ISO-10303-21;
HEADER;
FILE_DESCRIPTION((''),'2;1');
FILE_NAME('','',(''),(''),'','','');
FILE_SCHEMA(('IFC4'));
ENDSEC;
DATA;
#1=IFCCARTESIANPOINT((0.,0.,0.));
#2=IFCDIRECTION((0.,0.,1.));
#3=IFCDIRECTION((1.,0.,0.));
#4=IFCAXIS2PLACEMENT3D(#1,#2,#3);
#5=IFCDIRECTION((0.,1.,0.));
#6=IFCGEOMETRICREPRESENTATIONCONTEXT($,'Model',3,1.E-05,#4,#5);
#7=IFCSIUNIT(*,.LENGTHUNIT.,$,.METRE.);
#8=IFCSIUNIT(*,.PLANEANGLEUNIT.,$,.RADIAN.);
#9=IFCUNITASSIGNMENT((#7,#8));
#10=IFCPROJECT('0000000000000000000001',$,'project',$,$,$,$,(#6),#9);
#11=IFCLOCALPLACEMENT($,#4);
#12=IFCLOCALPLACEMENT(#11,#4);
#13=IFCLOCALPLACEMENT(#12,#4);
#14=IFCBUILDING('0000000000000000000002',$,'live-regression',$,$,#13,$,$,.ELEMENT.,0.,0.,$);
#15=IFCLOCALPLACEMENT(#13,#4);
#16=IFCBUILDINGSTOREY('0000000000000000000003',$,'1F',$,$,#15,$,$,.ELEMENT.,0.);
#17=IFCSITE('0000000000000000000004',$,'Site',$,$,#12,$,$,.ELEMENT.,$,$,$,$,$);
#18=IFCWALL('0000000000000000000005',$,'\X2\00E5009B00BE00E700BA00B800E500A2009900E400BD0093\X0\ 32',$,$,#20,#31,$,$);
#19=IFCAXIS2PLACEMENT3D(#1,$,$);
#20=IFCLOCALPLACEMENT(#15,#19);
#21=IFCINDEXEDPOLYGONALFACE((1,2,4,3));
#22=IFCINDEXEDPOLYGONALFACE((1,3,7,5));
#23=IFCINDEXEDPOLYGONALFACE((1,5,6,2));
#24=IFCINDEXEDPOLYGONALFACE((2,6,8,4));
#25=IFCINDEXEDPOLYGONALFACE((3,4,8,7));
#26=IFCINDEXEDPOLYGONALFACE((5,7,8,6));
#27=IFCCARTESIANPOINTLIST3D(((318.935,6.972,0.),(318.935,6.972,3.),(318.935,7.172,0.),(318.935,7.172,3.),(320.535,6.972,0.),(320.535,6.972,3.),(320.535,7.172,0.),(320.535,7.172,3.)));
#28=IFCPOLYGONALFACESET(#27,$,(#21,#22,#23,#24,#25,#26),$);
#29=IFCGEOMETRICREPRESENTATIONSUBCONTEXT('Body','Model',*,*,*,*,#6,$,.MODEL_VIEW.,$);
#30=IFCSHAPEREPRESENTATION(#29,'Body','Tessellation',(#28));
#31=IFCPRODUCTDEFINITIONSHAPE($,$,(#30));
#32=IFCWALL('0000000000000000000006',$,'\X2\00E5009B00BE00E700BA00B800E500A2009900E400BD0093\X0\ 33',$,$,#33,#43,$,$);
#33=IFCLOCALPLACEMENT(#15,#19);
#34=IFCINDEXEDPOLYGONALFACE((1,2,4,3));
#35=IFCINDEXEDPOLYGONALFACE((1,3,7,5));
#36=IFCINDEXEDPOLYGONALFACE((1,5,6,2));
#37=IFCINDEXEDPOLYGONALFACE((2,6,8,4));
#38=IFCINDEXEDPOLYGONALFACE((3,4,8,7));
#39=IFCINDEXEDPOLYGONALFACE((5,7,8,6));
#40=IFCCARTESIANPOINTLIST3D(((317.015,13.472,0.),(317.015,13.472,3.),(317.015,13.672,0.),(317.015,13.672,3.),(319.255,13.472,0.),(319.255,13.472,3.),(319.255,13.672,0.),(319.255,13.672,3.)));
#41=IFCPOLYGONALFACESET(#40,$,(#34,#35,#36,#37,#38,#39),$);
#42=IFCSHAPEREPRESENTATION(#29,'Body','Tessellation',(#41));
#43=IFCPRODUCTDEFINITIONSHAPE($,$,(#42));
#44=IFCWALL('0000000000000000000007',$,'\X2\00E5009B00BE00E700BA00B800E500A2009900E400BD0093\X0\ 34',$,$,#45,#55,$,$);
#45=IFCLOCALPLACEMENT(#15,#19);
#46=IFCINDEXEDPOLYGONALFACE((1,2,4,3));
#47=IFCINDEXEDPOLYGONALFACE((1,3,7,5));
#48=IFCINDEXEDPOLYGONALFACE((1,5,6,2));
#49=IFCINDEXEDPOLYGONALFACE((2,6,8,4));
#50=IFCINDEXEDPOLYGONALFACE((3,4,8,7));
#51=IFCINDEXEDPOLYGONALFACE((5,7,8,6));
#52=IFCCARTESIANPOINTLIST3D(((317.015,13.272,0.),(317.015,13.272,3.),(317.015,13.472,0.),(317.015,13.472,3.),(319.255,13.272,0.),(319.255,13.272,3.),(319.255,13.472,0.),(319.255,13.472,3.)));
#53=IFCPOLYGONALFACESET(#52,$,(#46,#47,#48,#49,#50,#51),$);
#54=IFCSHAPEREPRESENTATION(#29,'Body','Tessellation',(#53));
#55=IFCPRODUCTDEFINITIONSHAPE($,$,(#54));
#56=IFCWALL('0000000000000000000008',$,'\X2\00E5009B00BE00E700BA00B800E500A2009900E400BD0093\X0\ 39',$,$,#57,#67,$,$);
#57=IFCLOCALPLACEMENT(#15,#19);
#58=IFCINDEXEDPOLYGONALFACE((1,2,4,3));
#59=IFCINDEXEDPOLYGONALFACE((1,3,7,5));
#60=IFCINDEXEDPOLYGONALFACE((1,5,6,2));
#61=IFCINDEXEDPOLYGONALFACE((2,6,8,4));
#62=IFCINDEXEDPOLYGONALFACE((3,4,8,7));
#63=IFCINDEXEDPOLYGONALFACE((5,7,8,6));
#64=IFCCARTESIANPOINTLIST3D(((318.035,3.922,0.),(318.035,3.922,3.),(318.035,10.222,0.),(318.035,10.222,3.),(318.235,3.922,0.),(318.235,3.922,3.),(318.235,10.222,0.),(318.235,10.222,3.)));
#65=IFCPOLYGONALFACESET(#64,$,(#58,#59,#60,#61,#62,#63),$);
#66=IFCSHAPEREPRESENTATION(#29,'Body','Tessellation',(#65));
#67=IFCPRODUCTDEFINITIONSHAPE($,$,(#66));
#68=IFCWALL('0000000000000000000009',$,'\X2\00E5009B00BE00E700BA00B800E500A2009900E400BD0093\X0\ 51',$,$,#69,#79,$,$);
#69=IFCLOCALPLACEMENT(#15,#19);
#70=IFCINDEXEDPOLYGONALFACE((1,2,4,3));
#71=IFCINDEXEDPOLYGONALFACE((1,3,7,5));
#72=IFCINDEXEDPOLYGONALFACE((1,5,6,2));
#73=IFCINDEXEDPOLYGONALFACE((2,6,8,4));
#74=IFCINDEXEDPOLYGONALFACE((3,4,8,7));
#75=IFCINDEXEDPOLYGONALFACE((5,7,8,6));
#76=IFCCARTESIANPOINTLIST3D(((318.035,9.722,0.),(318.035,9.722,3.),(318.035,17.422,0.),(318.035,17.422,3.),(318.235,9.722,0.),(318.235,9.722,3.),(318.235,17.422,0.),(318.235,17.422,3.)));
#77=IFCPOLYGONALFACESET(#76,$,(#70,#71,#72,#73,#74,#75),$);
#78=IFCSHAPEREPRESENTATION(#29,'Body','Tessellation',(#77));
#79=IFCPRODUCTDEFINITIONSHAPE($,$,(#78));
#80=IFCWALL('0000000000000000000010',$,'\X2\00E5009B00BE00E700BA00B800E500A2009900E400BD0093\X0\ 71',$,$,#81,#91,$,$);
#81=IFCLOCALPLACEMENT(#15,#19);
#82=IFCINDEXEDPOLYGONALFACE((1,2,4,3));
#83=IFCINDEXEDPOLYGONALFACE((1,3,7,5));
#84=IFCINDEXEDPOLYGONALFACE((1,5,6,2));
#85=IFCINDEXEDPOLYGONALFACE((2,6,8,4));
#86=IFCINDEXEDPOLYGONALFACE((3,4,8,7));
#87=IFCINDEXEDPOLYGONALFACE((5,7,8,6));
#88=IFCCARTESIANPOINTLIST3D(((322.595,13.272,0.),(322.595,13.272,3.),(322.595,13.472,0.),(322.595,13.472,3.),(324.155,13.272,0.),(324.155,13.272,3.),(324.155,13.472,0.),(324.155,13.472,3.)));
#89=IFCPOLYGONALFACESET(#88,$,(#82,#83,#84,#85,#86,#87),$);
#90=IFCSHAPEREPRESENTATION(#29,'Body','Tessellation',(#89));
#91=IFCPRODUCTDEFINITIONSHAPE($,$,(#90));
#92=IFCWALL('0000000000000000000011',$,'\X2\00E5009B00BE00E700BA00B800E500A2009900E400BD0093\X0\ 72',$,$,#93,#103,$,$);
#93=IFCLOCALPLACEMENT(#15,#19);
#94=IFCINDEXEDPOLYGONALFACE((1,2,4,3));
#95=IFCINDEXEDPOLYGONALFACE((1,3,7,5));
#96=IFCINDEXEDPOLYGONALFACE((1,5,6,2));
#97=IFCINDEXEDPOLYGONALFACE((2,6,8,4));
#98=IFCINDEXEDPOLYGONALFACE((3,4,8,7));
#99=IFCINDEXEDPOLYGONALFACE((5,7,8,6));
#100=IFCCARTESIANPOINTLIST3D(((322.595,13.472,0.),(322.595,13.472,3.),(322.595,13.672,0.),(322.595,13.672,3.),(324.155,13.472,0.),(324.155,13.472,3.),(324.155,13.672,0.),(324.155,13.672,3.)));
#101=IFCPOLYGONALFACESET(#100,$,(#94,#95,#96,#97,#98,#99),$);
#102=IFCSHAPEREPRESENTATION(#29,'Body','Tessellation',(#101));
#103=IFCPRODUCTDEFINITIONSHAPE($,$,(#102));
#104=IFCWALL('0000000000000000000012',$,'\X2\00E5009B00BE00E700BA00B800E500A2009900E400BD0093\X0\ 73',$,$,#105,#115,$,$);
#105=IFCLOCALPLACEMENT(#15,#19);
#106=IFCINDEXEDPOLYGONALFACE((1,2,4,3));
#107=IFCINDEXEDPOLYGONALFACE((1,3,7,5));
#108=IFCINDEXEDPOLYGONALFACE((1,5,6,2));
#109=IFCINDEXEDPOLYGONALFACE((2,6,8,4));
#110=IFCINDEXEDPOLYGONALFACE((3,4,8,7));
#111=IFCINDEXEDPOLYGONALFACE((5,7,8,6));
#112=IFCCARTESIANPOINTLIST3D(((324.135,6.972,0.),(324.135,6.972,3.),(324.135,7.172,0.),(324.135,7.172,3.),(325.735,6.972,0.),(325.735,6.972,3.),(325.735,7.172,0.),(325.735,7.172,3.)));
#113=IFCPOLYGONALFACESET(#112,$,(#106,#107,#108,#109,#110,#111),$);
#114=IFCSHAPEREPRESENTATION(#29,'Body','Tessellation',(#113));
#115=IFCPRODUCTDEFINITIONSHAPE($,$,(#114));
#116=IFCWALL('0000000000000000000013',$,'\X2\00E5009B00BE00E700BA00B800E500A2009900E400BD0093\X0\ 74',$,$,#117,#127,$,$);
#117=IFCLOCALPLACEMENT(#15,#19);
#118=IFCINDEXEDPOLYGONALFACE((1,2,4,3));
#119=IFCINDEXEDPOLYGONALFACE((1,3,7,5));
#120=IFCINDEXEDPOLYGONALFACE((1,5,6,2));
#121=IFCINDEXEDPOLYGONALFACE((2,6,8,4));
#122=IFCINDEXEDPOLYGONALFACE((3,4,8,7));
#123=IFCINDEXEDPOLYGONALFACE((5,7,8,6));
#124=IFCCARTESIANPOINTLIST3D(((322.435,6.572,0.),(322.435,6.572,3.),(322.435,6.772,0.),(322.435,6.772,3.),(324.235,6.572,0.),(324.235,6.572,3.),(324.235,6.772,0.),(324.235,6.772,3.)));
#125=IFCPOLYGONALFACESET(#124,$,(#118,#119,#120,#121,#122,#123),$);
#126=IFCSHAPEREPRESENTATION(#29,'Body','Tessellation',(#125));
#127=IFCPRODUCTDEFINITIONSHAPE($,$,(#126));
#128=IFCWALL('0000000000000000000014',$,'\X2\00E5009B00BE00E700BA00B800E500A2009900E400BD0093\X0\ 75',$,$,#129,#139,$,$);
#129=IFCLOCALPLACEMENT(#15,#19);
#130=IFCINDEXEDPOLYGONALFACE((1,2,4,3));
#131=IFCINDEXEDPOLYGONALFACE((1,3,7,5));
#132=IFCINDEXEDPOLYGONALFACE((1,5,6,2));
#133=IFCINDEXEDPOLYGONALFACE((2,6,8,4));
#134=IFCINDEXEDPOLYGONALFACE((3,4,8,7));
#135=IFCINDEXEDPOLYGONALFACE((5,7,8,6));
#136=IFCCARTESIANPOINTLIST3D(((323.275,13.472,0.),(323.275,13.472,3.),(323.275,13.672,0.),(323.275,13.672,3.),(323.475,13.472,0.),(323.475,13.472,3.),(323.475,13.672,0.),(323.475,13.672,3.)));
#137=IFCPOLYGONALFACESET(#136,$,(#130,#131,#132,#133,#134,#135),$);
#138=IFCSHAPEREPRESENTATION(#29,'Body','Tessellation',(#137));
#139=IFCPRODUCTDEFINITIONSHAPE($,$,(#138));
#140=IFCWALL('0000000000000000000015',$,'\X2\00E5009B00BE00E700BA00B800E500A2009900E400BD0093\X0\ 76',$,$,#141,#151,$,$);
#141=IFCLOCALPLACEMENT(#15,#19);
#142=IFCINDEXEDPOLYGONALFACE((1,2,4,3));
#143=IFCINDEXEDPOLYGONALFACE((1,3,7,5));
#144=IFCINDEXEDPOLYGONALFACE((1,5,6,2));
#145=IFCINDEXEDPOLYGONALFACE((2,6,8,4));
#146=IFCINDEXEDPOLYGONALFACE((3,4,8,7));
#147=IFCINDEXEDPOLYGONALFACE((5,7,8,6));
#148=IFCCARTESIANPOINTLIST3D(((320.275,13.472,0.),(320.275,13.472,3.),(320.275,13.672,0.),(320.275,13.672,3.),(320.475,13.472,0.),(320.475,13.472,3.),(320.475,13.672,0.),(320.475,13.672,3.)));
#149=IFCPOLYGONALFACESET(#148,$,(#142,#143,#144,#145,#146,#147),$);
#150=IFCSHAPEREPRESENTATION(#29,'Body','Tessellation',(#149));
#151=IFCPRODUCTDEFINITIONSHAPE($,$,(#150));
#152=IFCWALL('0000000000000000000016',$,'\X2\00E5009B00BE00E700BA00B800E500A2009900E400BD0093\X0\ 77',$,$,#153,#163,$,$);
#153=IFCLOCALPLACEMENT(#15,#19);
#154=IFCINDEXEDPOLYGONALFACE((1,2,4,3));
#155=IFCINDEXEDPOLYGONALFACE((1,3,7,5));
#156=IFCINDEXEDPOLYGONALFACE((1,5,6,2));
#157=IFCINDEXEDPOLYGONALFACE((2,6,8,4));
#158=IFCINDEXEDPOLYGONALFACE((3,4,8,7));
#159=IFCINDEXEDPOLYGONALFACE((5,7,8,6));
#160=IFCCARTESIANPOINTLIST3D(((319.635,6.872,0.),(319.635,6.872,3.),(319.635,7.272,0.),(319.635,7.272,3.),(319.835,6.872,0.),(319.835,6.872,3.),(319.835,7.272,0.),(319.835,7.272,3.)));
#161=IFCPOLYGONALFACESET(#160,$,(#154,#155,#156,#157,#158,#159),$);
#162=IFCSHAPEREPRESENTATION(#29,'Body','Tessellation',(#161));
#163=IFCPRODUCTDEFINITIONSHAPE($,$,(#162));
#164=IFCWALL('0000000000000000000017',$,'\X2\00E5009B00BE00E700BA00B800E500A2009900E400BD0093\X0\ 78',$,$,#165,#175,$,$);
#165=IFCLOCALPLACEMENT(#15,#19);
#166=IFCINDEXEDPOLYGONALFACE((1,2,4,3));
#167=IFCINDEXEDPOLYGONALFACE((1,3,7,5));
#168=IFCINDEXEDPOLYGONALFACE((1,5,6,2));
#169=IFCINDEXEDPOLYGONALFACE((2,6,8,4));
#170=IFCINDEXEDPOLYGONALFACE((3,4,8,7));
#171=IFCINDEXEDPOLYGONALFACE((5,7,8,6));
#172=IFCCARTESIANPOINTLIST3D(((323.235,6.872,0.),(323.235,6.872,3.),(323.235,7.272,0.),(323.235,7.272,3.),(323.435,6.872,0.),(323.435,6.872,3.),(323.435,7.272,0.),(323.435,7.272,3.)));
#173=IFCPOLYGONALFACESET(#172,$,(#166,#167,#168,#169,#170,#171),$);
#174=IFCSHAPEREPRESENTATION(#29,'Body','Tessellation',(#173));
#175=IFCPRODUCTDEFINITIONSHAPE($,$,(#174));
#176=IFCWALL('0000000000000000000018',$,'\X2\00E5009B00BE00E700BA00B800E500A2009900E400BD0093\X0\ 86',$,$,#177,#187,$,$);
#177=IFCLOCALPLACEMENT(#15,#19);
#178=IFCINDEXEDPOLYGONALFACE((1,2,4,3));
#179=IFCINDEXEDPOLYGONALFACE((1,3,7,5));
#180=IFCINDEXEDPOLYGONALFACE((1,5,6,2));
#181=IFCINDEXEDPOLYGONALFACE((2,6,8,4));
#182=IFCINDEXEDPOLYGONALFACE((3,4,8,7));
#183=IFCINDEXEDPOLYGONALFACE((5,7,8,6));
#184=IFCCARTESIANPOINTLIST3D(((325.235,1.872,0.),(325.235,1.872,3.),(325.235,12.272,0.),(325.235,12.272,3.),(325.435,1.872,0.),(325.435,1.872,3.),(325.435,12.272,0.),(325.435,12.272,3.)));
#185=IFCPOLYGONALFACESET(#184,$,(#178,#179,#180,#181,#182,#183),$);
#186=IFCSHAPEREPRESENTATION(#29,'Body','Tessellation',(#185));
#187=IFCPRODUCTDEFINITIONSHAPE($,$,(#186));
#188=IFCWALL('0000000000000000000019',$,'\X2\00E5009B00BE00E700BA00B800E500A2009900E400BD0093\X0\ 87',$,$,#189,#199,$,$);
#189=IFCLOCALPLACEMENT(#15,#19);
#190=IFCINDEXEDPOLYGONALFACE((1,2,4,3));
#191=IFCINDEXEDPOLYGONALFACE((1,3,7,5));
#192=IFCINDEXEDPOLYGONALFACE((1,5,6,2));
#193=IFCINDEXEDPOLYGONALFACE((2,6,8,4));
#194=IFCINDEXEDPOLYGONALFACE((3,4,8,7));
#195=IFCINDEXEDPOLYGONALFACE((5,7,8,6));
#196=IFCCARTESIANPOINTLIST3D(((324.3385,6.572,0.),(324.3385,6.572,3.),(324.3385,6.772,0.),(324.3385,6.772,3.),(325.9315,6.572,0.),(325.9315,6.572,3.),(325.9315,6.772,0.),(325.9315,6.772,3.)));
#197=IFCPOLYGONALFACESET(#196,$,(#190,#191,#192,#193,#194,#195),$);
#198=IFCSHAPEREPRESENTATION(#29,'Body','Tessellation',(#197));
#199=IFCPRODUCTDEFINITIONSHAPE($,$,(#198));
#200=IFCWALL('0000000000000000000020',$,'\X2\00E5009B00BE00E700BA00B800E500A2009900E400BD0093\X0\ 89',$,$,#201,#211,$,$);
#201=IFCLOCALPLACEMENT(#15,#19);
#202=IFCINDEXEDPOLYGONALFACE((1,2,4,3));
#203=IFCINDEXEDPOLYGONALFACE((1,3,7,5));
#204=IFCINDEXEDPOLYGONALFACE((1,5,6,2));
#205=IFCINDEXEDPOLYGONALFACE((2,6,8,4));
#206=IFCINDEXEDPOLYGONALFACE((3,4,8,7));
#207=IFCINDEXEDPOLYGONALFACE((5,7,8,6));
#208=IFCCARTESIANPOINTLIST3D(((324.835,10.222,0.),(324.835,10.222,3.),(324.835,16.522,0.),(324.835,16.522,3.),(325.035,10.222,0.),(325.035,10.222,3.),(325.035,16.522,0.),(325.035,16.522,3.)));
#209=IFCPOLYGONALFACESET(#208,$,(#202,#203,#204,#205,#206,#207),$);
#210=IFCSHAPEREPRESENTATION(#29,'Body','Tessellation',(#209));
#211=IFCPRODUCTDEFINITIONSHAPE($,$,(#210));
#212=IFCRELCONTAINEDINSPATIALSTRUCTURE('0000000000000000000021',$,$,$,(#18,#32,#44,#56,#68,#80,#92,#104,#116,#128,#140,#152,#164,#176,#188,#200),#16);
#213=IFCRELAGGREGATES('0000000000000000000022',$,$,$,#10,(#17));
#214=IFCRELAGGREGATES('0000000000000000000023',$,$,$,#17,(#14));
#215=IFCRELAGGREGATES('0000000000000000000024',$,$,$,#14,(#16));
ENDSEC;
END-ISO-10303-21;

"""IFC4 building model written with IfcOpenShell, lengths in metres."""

from ifc_helpers import new_model, si_unit, direction, frame, frame_2d, origin_with_axes, place, context, subcontext, project, spatial, rectangle, extrude, element, save


model = new_model("IFC4")

# Units and contexts
model_context = context("Model", 3, precision=1e-05, world=origin_with_axes(), true_north=direction((0.0, 1.0, 0.0)))
body_context = subcontext(model_context, "Body", "Model", "MODEL_VIEW")
ifc_project = project(units=[si_unit("LENGTHUNIT", "METRE"), si_unit("PLANEANGLEUNIT", "RADIAN")], contexts=[model_context])

# Site, building, storey
placement = place(None, origin_with_axes())
site_placement = place(placement, origin_with_axes())
site = spatial("IfcSite", under=ifc_project, at=site_placement, Name="Site", CompositionType="ELEMENT")
building_placement = place(site_placement, origin_with_axes())
building = spatial("IfcBuilding", under=site, at=building_placement, Name="live-regression", CompositionType="ELEMENT", ElevationOfRefHeight=0.0, ElevationOfTerrain=0.0)
storey_placement = place(building_placement, origin_with_axes())
storey = spatial("IfcBuildingStorey", under=building, at=storey_placement, Name="1F", CompositionType="ELEMENT", Elevation=0.0)

# Walls
wall_1_placement = place(storey_placement, frame((319.735, 7.072, 0.0), z_axis=(0.0, 0.0, 1.0), x_axis=(-1.0, 0.0, 0.0)))
element("IfcWall", 1, at=wall_1_placement, inside=storey, Name="å\u009b¾çº¸å¢\u0099ä½\u0093 32", context=body_context, shape_type="SweptSolid", body=[
    extrude(rectangle(XDim=1.6, YDim=0.2, at=frame_2d((0.0, 0.0), x_axis=(1.0, 0.0, 0.0))), frame((0.0, 0.0, 0.0), z_axis=(0.0, 0.0, 1.0)), (0.0, 0.0, 1.0), 3.0),
])
for number, where, z_axis, x_axis, name in (
    (2, (318.135, 13.572, 0.0), (0.0, 0.0, 1.0), (1.0, 0.0, 0.0), "å\u009b¾çº¸å¢\u0099ä½\u0093 33"),
    (3, (318.135, 13.372, 0.0), (0.0, 0.0, 1.0), (1.0, 0.0, 0.0), "å\u009b¾çº¸å¢\u0099ä½\u0093 34"),
):
    element("IfcWall", number, at=place(storey_placement, frame(where, z_axis=z_axis, x_axis=x_axis)), inside=storey, Name=name, context=body_context, shape_type="SweptSolid", body=[
        extrude(rectangle(XDim=2.24, YDim=0.2, at=frame_2d((0.0, 0.0), x_axis=(1.0, 0.0, 0.0))), frame((0.0, 0.0, 0.0), z_axis=(0.0, 0.0, 1.0)), (0.0, 0.0, 1.0), 3.0),
    ])
wall_2_placement = place(storey_placement, frame((318.135, 7.072, 0.0), z_axis=(0.0, 0.0, 1.0), x_axis=(0.0, 1.0, 0.0)))
element("IfcWall", 4, at=wall_2_placement, inside=storey, Name="å\u009b¾çº¸å¢\u0099ä½\u0093 39", context=body_context, shape_type="SweptSolid", body=[
    extrude(rectangle(XDim=6.3, YDim=0.2, at=frame_2d((0.0, 0.0), x_axis=(1.0, 0.0, 0.0))), frame((0.0, 0.0, 0.0), z_axis=(0.0, 0.0, 1.0)), (0.0, 0.0, 1.0), 3.0),
])
wall_3_placement = place(storey_placement, frame((318.135, 13.572, 0.0), z_axis=(0.0, 0.0, 1.0), x_axis=(0.0, 1.0, 0.0)))
element("IfcWall", 5, at=wall_3_placement, inside=storey, Name="å\u009b¾çº¸å¢\u0099ä½\u0093 51", context=body_context, shape_type="SweptSolid", body=[
    extrude(rectangle(XDim=7.7, YDim=0.2, at=frame_2d((0.0, 0.0), x_axis=(1.0, 0.0, 0.0))), frame((0.0, 0.0, 0.0), z_axis=(0.0, 0.0, 1.0)), (0.0, 0.0, 1.0), 3.0),
])
for number, where, z_axis, x_axis, name in (
    (6, (323.375, 13.372, 0.0), (0.0, 0.0, 1.0), (1.0, 0.0, 0.0), "å\u009b¾çº¸å¢\u0099ä½\u0093 71"),
    (7, (323.375, 13.572, 0.0), (0.0, 0.0, 1.0), (1.0, 0.0, 0.0), "å\u009b¾çº¸å¢\u0099ä½\u0093 72"),
):
    element("IfcWall", number, at=place(storey_placement, frame(where, z_axis=z_axis, x_axis=x_axis)), inside=storey, Name=name, context=body_context, shape_type="SweptSolid", body=[
        extrude(rectangle(XDim=1.56, YDim=0.2, at=frame_2d((0.0, 0.0), x_axis=(1.0, 0.0, 0.0))), frame((0.0, 0.0, 0.0), z_axis=(0.0, 0.0, 1.0)), (0.0, 0.0, 1.0), 3.0),
    ])
wall_4_placement = place(storey_placement, frame((324.935, 7.072, 0.0), z_axis=(0.0, 0.0, 1.0), x_axis=(-1.0, 0.0, 0.0)))
element("IfcWall", 8, at=wall_4_placement, inside=storey, Name="å\u009b¾çº¸å¢\u0099ä½\u0093 73", context=body_context, shape_type="SweptSolid", body=[
    extrude(rectangle(XDim=1.6, YDim=0.2, at=frame_2d((0.0, 0.0), x_axis=(1.0, 0.0, 0.0))), frame((0.0, 0.0, 0.0), z_axis=(0.0, 0.0, 1.0)), (0.0, 0.0, 1.0), 3.0),
])
wall_5_placement = place(storey_placement, frame((323.335, 6.672, 0.0), z_axis=(0.0, 0.0, 1.0), x_axis=(1.0, 0.0, 0.0)))
element("IfcWall", 9, at=wall_5_placement, inside=storey, Name="å\u009b¾çº¸å¢\u0099ä½\u0093 74", context=body_context, shape_type="SweptSolid", body=[
    extrude(rectangle(XDim=1.8, YDim=0.2, at=frame_2d((0.0, 0.0), x_axis=(1.0, 0.0, 0.0))), frame((0.0, 0.0, 0.0), z_axis=(0.0, 0.0, 1.0)), (0.0, 0.0, 1.0), 3.0),
])
for number, where, z_axis, x_axis, name in (
    (10, (323.375, 13.572, 0.0), (0.0, 0.0, 1.0), (0.0, -1.0, 0.0), "å\u009b¾çº¸å¢\u0099ä½\u0093 75"),
    (11, (320.375, 13.572, 0.0), (0.0, 0.0, 1.0), (0.0, -1.0, 0.0), "å\u009b¾çº¸å¢\u0099ä½\u0093 76"),
):
    element("IfcWall", number, at=place(storey_placement, frame(where, z_axis=z_axis, x_axis=x_axis)), inside=storey, Name=name, context=body_context, shape_type="SweptSolid", body=[
        extrude(rectangle(XDim=0.2, YDim=0.2, at=frame_2d((0.0, 0.0), x_axis=(1.0, 0.0, 0.0))), frame((0.0, 0.0, 0.0), z_axis=(0.0, 0.0, 1.0)), (0.0, 0.0, 1.0), 3.0),
    ])
for number, where, z_axis, x_axis, name in (
    (12, (319.735, 7.072, 0.0), (0.0, 0.0, 1.0), (0.0, -1.0, 0.0), "å\u009b¾çº¸å¢\u0099ä½\u0093 77"),
    (13, (323.335, 7.072, 0.0), (0.0, 0.0, 1.0), (0.0, -1.0, 0.0), "å\u009b¾çº¸å¢\u0099ä½\u0093 78"),
):
    element("IfcWall", number, at=place(storey_placement, frame(where, z_axis=z_axis, x_axis=x_axis)), inside=storey, Name=name, context=body_context, shape_type="SweptSolid", body=[
        extrude(rectangle(XDim=0.4, YDim=0.2, at=frame_2d((0.0, 0.0), x_axis=(1.0, 0.0, 0.0))), frame((0.0, 0.0, 0.0), z_axis=(0.0, 0.0, 1.0)), (0.0, 0.0, 1.0), 3.0),
    ])
wall_6_placement = place(storey_placement, frame((325.335, 7.072, 0.0), z_axis=(0.0, 0.0, 1.0), x_axis=(0.0, 1.0, 0.0)))
element("IfcWall", 14, at=wall_6_placement, inside=storey, Name="å\u009b¾çº¸å¢\u0099ä½\u0093 86", context=body_context, shape_type="SweptSolid", body=[
    extrude(rectangle(XDim=10.4, YDim=0.2, at=frame_2d((0.0, 0.0), x_axis=(1.0, 0.0, 0.0))), frame((0.0, 0.0, 0.0), z_axis=(0.0, 0.0, 1.0)), (0.0, 0.0, 1.0), 3.0),
])
wall_7_placement = place(storey_placement, frame((325.135, 6.672, 0.0), z_axis=(0.0, 0.0, 1.0), x_axis=(1.0, 0.0, 0.0)))
element("IfcWall", 15, at=wall_7_placement, inside=storey, Name="å\u009b¾çº¸å¢\u0099ä½\u0093 87", context=body_context, shape_type="SweptSolid", body=[
    extrude(rectangle(XDim=1.593, YDim=0.2, at=frame_2d((0.0, 0.0), x_axis=(1.0, 0.0, 0.0))), frame((0.0, 0.0, 0.0), z_axis=(0.0, 0.0, 1.0)), (0.0, 0.0, 1.0), 3.0),
])
wall_8_placement = place(storey_placement, frame((324.935, 13.372, 0.0), z_axis=(0.0, 0.0, 1.0), x_axis=(0.0, -1.0, 0.0)))
element("IfcWall", 16, at=wall_8_placement, inside=storey, Name="å\u009b¾çº¸å¢\u0099ä½\u0093 89", context=body_context, shape_type="SweptSolid", body=[
    extrude(rectangle(XDim=6.3, YDim=0.2, at=frame_2d((0.0, 0.0), x_axis=(1.0, 0.0, 0.0))), frame((0.0, 0.0, 0.0), z_axis=(0.0, 0.0, 1.0)), (0.0, 0.0, 1.0), 3.0),
])

save(model, "model.ifc")
